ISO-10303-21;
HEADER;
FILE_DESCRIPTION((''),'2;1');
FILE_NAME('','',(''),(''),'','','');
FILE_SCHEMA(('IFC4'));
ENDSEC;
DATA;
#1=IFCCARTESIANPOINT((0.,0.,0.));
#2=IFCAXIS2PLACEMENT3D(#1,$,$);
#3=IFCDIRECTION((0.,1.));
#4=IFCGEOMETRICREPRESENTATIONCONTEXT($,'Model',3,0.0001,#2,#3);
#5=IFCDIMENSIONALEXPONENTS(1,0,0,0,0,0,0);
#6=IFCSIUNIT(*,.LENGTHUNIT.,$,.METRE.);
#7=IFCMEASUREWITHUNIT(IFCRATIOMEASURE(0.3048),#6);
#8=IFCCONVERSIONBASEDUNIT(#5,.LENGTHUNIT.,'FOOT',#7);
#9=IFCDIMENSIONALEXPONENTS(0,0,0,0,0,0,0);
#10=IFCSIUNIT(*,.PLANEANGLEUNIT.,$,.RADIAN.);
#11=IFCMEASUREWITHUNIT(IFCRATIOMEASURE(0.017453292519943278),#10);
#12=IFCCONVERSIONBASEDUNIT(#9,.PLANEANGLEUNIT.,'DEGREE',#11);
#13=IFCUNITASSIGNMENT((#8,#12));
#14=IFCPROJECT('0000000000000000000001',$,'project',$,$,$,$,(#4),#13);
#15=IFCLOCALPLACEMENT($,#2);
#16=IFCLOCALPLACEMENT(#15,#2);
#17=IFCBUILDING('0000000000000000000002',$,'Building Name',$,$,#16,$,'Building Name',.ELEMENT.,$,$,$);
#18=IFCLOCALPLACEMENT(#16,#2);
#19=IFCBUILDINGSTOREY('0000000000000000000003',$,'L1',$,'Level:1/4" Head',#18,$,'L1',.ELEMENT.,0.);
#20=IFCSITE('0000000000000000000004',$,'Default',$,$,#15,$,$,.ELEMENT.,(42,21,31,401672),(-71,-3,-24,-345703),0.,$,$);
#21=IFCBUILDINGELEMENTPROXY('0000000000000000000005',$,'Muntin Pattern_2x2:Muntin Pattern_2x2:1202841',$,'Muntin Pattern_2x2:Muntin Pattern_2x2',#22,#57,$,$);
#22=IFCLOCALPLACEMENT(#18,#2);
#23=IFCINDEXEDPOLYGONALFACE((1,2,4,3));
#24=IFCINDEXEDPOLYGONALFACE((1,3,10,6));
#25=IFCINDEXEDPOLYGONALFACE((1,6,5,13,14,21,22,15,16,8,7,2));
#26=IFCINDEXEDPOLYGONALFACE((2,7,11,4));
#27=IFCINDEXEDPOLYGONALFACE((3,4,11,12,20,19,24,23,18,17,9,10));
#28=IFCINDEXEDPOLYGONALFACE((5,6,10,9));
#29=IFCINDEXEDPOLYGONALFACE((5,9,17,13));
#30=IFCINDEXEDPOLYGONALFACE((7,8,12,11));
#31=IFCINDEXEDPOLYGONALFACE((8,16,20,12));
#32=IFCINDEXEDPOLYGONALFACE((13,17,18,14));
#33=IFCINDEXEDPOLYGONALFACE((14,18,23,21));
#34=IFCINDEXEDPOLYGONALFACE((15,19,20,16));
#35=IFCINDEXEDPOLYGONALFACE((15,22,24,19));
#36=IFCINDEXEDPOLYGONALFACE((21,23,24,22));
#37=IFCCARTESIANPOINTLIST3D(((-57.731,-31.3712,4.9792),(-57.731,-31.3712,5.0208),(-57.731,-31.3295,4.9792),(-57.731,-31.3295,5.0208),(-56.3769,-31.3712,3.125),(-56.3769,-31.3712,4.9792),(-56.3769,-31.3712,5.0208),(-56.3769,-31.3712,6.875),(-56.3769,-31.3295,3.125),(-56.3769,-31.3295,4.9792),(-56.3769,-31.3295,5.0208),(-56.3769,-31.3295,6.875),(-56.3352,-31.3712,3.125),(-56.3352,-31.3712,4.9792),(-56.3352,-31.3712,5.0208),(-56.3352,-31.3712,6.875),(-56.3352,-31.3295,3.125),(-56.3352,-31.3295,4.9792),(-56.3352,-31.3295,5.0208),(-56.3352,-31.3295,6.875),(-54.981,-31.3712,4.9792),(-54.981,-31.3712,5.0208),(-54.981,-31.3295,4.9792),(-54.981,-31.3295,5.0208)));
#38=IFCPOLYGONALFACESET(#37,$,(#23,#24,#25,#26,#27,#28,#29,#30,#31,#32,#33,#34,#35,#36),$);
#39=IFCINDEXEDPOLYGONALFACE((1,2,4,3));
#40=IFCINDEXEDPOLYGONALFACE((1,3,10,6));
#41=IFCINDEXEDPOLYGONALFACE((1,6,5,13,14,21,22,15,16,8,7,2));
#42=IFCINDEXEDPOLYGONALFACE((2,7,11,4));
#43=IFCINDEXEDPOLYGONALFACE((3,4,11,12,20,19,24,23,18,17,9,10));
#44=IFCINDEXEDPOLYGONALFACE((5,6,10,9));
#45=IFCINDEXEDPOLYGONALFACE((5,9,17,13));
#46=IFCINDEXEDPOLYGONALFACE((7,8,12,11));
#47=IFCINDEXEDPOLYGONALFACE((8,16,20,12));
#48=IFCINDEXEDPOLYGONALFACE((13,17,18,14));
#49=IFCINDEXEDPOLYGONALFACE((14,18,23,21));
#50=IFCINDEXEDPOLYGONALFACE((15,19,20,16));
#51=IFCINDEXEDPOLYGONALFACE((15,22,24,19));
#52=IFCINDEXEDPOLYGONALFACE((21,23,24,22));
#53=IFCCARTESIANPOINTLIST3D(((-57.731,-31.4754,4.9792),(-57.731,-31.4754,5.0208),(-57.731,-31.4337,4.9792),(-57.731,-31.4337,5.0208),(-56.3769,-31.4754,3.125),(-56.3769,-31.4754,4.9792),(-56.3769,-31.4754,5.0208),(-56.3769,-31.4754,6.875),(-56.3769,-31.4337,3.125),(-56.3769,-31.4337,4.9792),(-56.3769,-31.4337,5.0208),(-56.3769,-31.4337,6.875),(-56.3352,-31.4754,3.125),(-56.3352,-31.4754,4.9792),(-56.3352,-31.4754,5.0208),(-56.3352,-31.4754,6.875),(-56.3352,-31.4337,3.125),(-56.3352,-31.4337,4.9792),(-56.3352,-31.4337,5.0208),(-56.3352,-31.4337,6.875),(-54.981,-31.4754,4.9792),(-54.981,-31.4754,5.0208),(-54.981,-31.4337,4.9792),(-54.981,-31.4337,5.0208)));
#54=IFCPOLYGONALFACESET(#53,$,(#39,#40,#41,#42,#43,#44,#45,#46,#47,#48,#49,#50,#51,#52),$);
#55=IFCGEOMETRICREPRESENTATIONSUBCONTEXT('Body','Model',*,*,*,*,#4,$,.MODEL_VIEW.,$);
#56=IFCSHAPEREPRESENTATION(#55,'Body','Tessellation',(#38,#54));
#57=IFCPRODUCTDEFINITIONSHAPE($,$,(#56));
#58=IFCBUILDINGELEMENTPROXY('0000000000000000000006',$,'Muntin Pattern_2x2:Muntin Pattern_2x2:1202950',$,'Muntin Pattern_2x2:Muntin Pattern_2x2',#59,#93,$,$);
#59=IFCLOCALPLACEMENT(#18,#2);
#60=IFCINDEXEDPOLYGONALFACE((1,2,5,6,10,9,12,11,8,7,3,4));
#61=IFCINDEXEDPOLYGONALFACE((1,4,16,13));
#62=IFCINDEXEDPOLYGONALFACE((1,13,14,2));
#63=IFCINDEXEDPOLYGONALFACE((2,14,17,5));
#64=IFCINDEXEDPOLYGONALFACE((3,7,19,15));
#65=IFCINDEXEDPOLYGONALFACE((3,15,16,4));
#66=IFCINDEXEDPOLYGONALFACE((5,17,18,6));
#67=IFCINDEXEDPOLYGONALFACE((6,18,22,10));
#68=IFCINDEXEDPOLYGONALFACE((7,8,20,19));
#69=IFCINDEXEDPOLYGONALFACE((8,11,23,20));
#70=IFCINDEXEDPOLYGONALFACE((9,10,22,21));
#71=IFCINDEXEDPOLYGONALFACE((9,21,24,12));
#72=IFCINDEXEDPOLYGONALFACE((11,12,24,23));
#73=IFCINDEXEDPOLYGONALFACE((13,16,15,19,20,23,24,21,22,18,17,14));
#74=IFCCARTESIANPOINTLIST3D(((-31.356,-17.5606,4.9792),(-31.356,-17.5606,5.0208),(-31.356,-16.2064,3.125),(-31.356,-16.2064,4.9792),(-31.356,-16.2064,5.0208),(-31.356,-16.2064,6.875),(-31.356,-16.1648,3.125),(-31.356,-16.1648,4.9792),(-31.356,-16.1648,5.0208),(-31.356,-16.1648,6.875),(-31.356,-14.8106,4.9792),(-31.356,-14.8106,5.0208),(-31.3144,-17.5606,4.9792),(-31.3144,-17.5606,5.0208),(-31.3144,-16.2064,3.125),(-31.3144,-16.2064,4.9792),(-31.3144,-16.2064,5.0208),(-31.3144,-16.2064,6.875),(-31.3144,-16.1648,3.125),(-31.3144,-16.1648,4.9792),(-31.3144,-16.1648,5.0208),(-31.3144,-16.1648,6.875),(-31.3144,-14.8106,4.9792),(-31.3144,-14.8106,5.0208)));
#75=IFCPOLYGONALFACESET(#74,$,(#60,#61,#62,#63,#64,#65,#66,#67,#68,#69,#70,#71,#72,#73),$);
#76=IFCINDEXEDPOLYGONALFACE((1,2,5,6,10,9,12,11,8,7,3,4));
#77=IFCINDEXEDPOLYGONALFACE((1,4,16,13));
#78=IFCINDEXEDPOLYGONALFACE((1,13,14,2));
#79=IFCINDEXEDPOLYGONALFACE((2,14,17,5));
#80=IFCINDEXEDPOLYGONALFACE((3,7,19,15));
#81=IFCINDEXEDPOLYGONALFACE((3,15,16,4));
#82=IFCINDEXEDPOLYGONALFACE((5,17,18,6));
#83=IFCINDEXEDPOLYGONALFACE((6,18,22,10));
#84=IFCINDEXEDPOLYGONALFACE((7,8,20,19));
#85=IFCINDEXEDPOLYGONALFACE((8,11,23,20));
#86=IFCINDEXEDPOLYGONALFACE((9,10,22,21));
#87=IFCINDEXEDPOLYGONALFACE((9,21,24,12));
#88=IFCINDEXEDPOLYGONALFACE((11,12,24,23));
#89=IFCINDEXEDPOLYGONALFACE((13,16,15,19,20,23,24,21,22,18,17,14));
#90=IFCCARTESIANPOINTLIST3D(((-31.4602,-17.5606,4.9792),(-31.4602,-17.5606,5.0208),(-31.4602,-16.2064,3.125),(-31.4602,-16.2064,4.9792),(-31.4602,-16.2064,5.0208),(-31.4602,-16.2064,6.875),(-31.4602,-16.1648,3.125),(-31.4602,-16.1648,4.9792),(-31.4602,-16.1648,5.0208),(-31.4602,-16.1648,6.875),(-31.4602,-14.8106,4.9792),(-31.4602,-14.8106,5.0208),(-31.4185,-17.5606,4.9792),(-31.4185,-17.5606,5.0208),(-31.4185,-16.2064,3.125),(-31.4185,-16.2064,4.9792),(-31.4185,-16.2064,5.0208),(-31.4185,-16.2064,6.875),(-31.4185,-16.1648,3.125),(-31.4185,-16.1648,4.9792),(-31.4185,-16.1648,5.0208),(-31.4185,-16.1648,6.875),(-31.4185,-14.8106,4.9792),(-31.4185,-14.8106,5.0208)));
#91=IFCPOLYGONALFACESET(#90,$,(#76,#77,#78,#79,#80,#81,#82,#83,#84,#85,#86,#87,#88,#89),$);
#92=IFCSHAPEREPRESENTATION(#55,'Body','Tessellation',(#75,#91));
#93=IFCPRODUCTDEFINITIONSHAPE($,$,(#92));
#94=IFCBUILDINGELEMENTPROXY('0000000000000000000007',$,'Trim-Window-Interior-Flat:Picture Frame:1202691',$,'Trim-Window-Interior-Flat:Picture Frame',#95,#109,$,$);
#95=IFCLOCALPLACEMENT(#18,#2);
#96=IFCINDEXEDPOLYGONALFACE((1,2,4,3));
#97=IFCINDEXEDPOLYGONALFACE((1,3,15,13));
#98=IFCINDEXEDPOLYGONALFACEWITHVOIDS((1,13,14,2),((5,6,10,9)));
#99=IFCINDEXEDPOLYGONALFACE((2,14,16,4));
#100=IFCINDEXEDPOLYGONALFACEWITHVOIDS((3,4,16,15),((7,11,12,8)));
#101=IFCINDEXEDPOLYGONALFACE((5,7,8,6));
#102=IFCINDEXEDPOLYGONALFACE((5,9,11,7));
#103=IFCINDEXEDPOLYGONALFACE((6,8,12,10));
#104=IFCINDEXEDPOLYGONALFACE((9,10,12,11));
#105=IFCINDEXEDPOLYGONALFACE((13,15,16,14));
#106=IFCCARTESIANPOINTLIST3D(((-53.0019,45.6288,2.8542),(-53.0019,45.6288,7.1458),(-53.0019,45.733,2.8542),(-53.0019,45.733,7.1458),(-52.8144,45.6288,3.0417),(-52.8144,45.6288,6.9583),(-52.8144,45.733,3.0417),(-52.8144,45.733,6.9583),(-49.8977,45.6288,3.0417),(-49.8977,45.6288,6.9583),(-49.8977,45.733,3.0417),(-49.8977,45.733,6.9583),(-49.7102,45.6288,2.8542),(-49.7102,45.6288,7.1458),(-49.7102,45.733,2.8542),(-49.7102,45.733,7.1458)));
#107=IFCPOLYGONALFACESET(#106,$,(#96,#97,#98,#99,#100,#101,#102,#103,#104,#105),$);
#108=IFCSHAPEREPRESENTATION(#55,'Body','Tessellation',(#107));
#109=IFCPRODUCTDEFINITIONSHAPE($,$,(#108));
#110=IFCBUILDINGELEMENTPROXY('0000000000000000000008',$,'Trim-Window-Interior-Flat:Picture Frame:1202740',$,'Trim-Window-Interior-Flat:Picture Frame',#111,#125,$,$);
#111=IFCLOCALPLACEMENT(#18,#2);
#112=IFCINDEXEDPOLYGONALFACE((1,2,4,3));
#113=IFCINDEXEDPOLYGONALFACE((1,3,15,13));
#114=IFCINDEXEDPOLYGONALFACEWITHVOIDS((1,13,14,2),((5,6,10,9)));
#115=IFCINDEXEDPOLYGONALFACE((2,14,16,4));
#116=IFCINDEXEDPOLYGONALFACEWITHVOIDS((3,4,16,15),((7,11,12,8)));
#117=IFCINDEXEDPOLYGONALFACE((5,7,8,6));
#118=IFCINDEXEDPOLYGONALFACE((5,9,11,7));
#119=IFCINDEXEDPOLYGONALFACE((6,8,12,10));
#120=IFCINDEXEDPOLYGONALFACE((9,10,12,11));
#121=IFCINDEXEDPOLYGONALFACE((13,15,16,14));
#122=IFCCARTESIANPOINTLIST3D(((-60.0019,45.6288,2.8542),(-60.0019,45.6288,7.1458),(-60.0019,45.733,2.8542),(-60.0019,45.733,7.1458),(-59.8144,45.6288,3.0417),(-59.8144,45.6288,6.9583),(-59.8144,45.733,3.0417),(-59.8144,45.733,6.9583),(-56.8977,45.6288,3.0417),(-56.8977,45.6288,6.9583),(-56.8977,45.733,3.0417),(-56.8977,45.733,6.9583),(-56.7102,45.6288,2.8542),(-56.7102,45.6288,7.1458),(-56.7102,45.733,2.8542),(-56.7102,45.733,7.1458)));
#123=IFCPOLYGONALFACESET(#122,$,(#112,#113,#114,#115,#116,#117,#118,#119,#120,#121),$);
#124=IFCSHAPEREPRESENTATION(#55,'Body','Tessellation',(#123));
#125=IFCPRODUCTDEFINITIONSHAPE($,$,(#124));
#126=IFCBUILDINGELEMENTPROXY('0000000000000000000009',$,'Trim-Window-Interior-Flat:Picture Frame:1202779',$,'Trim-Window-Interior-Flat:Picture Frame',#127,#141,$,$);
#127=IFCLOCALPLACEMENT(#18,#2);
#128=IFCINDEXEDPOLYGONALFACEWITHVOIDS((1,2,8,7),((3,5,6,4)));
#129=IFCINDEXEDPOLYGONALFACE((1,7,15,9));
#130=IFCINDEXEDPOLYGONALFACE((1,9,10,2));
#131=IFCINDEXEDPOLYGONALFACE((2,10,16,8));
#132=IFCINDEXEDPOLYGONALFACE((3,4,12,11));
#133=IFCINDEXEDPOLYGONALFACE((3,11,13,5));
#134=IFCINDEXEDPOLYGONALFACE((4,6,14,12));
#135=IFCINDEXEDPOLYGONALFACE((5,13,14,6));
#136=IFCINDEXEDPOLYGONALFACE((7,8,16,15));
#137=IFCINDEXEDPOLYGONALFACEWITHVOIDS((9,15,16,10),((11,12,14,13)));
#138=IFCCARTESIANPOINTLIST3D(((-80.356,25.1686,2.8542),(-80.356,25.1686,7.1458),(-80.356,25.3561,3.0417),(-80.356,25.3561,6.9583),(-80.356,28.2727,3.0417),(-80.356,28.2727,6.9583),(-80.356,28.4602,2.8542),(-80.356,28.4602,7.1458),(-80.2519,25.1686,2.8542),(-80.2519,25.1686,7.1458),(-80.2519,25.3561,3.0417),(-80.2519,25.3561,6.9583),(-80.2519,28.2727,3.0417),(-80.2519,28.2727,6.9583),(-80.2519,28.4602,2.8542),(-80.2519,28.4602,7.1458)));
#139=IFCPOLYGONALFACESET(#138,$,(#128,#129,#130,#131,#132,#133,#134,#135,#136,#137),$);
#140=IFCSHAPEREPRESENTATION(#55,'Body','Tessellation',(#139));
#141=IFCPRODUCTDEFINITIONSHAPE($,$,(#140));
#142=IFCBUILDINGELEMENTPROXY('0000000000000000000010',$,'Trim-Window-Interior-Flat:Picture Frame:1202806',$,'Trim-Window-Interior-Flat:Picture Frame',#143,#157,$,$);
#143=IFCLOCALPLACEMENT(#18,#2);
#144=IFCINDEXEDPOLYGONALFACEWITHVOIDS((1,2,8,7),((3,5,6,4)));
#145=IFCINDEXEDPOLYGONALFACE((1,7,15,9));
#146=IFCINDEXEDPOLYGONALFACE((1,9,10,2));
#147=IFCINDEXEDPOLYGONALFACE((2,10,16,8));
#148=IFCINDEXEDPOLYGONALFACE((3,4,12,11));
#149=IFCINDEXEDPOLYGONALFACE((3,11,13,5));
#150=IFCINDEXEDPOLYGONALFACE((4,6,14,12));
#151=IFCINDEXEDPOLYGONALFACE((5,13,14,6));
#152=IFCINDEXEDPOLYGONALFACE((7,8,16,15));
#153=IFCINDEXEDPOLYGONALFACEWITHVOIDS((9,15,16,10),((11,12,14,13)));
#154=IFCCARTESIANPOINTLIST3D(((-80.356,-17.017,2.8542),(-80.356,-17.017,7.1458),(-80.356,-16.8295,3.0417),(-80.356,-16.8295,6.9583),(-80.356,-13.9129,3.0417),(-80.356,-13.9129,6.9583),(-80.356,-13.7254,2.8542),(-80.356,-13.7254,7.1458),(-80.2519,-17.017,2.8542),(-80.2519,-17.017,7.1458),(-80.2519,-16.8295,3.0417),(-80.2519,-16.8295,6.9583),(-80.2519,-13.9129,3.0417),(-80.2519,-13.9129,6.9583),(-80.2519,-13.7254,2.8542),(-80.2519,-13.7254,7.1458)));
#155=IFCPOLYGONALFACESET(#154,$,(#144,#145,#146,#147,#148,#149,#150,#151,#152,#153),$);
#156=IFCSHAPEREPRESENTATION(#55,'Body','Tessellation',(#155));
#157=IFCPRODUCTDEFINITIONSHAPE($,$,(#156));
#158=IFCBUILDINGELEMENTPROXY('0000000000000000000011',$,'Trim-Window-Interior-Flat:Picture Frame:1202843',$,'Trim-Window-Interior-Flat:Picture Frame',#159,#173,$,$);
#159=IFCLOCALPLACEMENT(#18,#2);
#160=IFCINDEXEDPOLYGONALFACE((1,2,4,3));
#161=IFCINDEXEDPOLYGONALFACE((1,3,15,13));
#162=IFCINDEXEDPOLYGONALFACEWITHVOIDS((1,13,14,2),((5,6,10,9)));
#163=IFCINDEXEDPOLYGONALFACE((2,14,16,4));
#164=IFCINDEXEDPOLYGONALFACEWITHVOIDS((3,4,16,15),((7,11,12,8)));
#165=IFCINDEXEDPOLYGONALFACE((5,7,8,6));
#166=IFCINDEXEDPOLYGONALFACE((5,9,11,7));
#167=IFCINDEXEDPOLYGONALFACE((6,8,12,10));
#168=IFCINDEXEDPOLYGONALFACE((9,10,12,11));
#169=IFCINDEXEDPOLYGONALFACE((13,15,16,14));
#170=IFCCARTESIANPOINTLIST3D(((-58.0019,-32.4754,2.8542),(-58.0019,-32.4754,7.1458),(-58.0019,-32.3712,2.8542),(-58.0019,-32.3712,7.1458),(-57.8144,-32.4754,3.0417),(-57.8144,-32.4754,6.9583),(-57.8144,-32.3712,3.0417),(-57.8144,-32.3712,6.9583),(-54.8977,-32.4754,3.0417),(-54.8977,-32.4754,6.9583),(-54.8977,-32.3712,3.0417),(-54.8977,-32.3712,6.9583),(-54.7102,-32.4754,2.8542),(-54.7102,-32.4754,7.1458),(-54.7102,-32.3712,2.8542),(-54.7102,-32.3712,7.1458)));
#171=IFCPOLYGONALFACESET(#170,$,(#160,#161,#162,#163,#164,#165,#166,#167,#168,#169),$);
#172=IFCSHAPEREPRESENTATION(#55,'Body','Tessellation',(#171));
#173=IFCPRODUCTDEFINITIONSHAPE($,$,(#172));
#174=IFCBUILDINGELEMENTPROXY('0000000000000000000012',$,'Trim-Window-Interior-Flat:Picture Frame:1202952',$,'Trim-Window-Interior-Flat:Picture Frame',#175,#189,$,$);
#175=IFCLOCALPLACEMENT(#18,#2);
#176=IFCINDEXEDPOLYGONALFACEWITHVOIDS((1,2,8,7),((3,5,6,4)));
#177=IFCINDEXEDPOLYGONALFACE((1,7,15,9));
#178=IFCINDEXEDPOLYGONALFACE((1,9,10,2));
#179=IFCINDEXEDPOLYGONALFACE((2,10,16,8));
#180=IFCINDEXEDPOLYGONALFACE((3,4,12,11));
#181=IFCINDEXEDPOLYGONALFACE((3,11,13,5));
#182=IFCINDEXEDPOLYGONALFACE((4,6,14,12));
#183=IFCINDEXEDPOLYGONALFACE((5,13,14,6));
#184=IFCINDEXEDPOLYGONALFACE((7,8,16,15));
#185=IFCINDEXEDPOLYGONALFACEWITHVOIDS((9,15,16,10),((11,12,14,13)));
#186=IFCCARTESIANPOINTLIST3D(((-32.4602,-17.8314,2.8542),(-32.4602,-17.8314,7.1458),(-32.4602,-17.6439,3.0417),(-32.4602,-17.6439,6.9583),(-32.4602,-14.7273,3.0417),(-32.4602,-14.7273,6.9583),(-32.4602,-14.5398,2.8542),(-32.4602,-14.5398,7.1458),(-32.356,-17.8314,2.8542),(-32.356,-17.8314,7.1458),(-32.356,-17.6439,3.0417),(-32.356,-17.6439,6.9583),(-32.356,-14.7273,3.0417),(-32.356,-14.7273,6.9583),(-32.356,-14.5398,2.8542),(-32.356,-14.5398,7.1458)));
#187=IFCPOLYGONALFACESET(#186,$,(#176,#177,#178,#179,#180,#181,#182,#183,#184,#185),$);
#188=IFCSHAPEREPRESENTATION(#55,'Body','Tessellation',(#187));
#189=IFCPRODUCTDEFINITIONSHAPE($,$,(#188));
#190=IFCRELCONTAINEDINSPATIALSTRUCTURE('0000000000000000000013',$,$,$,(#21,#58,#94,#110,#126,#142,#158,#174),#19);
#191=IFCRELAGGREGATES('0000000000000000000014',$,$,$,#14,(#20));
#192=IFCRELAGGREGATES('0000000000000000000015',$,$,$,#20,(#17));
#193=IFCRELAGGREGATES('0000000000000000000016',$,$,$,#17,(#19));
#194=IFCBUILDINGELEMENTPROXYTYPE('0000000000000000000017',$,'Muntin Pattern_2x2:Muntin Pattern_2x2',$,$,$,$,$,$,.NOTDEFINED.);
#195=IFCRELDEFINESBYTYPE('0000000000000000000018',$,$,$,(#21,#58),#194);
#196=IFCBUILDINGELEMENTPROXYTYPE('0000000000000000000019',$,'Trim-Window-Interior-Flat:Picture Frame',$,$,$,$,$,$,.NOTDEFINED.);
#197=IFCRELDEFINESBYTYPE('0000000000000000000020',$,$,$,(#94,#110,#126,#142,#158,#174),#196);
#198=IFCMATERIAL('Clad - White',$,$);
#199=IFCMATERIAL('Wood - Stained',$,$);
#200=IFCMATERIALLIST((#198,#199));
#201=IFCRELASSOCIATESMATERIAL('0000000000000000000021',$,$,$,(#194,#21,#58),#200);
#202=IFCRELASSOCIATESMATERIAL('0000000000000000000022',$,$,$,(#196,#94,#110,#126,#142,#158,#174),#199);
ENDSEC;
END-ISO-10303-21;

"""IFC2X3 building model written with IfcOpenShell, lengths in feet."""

from ifc_helpers import new_model, entity, si_unit, converted_unit, direction, frame, origin, place, context, subcontext, project, spatial, polyline, outline, extrude, source, transform, mapped, material, material_list, type_object, type_shapes, element, save


model = new_model("IFC2X3")

# Units and contexts
model_context = context("Model", 3, precision=0.0001, world=origin(), true_north=direction((0.0, 1.0)))
body_context = subcontext(model_context, "Body", "Model", "MODEL_VIEW")
ifc_project = project(units=[converted_unit("LENGTHUNIT", "FOOT", entity("IfcRatioMeasure", 0.3048), si_unit("LENGTHUNIT", "METRE"), dimensions=[1, 0, 0, 0, 0, 0, 0]), converted_unit("PLANEANGLEUNIT", "DEGREE", entity("IfcRatioMeasure", 0.017453292519943278), si_unit("PLANEANGLEUNIT", "RADIAN"), dimensions=[0, 0, 0, 0, 0, 0, 0])], contexts=[model_context])

# Site, building, storey
site_placement = place(None, origin())
site = spatial("IfcSite", under=ifc_project, at=site_placement, Name="Default", CompositionType="ELEMENT", RefLatitude=(42, 21, 31, 401672), RefLongitude=(-71, -3, -24, -345703), RefElevation=0.0)
building_placement = place(site_placement, origin())
building = spatial("IfcBuilding", under=site, at=building_placement, Name="Building Name", LongName="Building Name", CompositionType="ELEMENT")
storey_placement = place(building_placement, origin())
storey = spatial("IfcBuildingStorey", under=building, at=storey_placement, Name="L1", ObjectType="Level:1/4\" Head", LongName="L1", CompositionType="ELEMENT", Elevation=0.0)

# Building element proxies
ifc_material_1 = material(Name="Clad - White")
ifc_material_2 = material(Name="Wood - Stained")
ifc_material_list = material_list([ifc_material_1, ifc_material_2])
building_element_proxy_type_1 = type_object("IfcBuildingElementProxyType", Name="Muntin Pattern_2x2:Muntin Pattern_2x2", PredefinedType="NOTDEFINED", material=ifc_material_list)
shared_shape_1 = source(origin(), body_context, "Body", "SweptSolid", [
    extrude(outline(polyline([(0.0208, -0.0208), (1.875, -0.0208), (1.875, 0.0208), (0.0208, 0.0208), (0.0208, 1.375), (-0.0208, 1.375), (-0.0208, 0.0208), (-1.875, 0.0208), (-1.875, -0.0208), (-0.0208, -0.0208), (-0.0208, -1.375), (0.0208, -1.375), (0.0208, -0.0208)])), frame((0.0, -0.0729, 1.875), z_axis=(0.0, 1.0, 0.0), x_axis=(0.0, 0.0, 1.0)), (0.0, 0.0, 1.0), 0.0417),
    extrude(outline(polyline([(0.0208, -0.0208), (1.875, -0.0208), (1.875, 0.0208), (0.0208, 0.0208), (0.0208, 1.375), (-0.0208, 1.375), (-0.0208, 0.0208), (-1.875, 0.0208), (-1.875, -0.0208), (-0.0208, -0.0208), (-0.0208, -1.375), (0.0208, -1.375), (0.0208, -0.0208)])), frame((0.0, 0.0313, 1.875), z_axis=(0.0, 1.0, 0.0), x_axis=(0.0, 0.0, 1.0)), (0.0, 0.0, 1.0), 0.0417),
])
type_shapes(building_element_proxy_type_1, [shared_shape_1])
for number, where, z_axis, x_axis, name in (
    (1, (-56.356, -31.4025, 3.125), (0.0, 0.0, 1.0), (-1.0, 0.0, 0.0), "Muntin Pattern_2x2:Muntin Pattern_2x2:1202841"),
    (2, (-31.3873, -16.1856, 3.125), (0.0, 0.0, 1.0), (0.0, 1.0, 0.0), "Muntin Pattern_2x2:Muntin Pattern_2x2:1202950"),
):
    element("IfcBuildingElementProxy", number, at=place(storey_placement, frame(where, z_axis=z_axis, x_axis=x_axis)), inside=storey, type_object=building_element_proxy_type_1, material=ifc_material_list, Name=name, ObjectType="Muntin Pattern_2x2:Muntin Pattern_2x2", context=body_context, shape_type="MappedRepresentation", body=[
        mapped(shared_shape_1, transform((0.0, 0.0, 0.0), scale=1.0)),
    ])
building_element_proxy_type_2 = type_object("IfcBuildingElementProxyType", Name="Trim-Window-Interior-Flat:Picture Frame", PredefinedType="NOTDEFINED", material=ifc_material_2)
shared_shape_2 = source(origin(), body_context, "Body", "SweptSolid", [
    extrude(outline(polyline([(-1.6458, -2.1458), (1.6458, -2.1458), (1.6458, 2.1458), (-1.6458, 2.1458), (-1.6458, -2.1458)]), holes=[polyline([(-1.4583, -1.9583), (-1.4583, 1.9583), (1.4583, 1.9583), (1.4583, -1.9583), (-1.4583, -1.9583)])]), frame((0.0, -2.0, 0.0), z_axis=(0.0, 0.0, 1.0), x_axis=(-1.0, 0.0, 0.0)), (0.0, 0.0, 1.0), 0.1042),
])
type_shapes(building_element_proxy_type_2, [shared_shape_2])
for number, where, z_axis, x_axis, name in (
    (3, (-51.356, 45.6288, 7.0), (0.0, 1.0, 0.0), (-1.0, 0.0, 0.0), "Trim-Window-Interior-Flat:Picture Frame:1202691"),
    (4, (-58.356, 45.6288, 7.0), (0.0, 1.0, 0.0), (-1.0, 0.0, 0.0), "Trim-Window-Interior-Flat:Picture Frame:1202740"),
    (5, (-80.356, 26.8144, 7.0), (1.0, 0.0, 0.0), (0.0, 1.0, 0.0), "Trim-Window-Interior-Flat:Picture Frame:1202779"),
    (6, (-80.356, -15.3712, 7.0), (1.0, 0.0, 0.0), (0.0, 1.0, 0.0), "Trim-Window-Interior-Flat:Picture Frame:1202806"),
    (7, (-56.356, -32.3712, 7.0), (0.0, -1.0, 0.0), (1.0, 0.0, 0.0), "Trim-Window-Interior-Flat:Picture Frame:1202843"),
    (8, (-32.356, -16.1856, 7.0), (-1.0, 0.0, 0.0), (0.0, -1.0, 0.0), "Trim-Window-Interior-Flat:Picture Frame:1202952"),
):
    element("IfcBuildingElementProxy", number, at=place(storey_placement, frame(where, z_axis=z_axis, x_axis=x_axis)), inside=storey, type_object=building_element_proxy_type_2, material=ifc_material_2, Name=name, ObjectType="Trim-Window-Interior-Flat:Picture Frame", context=body_context, shape_type="MappedRepresentation", body=[
        mapped(shared_shape_2, transform((0.0, 0.0, 0.0), scale=1.0)),
    ])

save(model, "model.ifc")
